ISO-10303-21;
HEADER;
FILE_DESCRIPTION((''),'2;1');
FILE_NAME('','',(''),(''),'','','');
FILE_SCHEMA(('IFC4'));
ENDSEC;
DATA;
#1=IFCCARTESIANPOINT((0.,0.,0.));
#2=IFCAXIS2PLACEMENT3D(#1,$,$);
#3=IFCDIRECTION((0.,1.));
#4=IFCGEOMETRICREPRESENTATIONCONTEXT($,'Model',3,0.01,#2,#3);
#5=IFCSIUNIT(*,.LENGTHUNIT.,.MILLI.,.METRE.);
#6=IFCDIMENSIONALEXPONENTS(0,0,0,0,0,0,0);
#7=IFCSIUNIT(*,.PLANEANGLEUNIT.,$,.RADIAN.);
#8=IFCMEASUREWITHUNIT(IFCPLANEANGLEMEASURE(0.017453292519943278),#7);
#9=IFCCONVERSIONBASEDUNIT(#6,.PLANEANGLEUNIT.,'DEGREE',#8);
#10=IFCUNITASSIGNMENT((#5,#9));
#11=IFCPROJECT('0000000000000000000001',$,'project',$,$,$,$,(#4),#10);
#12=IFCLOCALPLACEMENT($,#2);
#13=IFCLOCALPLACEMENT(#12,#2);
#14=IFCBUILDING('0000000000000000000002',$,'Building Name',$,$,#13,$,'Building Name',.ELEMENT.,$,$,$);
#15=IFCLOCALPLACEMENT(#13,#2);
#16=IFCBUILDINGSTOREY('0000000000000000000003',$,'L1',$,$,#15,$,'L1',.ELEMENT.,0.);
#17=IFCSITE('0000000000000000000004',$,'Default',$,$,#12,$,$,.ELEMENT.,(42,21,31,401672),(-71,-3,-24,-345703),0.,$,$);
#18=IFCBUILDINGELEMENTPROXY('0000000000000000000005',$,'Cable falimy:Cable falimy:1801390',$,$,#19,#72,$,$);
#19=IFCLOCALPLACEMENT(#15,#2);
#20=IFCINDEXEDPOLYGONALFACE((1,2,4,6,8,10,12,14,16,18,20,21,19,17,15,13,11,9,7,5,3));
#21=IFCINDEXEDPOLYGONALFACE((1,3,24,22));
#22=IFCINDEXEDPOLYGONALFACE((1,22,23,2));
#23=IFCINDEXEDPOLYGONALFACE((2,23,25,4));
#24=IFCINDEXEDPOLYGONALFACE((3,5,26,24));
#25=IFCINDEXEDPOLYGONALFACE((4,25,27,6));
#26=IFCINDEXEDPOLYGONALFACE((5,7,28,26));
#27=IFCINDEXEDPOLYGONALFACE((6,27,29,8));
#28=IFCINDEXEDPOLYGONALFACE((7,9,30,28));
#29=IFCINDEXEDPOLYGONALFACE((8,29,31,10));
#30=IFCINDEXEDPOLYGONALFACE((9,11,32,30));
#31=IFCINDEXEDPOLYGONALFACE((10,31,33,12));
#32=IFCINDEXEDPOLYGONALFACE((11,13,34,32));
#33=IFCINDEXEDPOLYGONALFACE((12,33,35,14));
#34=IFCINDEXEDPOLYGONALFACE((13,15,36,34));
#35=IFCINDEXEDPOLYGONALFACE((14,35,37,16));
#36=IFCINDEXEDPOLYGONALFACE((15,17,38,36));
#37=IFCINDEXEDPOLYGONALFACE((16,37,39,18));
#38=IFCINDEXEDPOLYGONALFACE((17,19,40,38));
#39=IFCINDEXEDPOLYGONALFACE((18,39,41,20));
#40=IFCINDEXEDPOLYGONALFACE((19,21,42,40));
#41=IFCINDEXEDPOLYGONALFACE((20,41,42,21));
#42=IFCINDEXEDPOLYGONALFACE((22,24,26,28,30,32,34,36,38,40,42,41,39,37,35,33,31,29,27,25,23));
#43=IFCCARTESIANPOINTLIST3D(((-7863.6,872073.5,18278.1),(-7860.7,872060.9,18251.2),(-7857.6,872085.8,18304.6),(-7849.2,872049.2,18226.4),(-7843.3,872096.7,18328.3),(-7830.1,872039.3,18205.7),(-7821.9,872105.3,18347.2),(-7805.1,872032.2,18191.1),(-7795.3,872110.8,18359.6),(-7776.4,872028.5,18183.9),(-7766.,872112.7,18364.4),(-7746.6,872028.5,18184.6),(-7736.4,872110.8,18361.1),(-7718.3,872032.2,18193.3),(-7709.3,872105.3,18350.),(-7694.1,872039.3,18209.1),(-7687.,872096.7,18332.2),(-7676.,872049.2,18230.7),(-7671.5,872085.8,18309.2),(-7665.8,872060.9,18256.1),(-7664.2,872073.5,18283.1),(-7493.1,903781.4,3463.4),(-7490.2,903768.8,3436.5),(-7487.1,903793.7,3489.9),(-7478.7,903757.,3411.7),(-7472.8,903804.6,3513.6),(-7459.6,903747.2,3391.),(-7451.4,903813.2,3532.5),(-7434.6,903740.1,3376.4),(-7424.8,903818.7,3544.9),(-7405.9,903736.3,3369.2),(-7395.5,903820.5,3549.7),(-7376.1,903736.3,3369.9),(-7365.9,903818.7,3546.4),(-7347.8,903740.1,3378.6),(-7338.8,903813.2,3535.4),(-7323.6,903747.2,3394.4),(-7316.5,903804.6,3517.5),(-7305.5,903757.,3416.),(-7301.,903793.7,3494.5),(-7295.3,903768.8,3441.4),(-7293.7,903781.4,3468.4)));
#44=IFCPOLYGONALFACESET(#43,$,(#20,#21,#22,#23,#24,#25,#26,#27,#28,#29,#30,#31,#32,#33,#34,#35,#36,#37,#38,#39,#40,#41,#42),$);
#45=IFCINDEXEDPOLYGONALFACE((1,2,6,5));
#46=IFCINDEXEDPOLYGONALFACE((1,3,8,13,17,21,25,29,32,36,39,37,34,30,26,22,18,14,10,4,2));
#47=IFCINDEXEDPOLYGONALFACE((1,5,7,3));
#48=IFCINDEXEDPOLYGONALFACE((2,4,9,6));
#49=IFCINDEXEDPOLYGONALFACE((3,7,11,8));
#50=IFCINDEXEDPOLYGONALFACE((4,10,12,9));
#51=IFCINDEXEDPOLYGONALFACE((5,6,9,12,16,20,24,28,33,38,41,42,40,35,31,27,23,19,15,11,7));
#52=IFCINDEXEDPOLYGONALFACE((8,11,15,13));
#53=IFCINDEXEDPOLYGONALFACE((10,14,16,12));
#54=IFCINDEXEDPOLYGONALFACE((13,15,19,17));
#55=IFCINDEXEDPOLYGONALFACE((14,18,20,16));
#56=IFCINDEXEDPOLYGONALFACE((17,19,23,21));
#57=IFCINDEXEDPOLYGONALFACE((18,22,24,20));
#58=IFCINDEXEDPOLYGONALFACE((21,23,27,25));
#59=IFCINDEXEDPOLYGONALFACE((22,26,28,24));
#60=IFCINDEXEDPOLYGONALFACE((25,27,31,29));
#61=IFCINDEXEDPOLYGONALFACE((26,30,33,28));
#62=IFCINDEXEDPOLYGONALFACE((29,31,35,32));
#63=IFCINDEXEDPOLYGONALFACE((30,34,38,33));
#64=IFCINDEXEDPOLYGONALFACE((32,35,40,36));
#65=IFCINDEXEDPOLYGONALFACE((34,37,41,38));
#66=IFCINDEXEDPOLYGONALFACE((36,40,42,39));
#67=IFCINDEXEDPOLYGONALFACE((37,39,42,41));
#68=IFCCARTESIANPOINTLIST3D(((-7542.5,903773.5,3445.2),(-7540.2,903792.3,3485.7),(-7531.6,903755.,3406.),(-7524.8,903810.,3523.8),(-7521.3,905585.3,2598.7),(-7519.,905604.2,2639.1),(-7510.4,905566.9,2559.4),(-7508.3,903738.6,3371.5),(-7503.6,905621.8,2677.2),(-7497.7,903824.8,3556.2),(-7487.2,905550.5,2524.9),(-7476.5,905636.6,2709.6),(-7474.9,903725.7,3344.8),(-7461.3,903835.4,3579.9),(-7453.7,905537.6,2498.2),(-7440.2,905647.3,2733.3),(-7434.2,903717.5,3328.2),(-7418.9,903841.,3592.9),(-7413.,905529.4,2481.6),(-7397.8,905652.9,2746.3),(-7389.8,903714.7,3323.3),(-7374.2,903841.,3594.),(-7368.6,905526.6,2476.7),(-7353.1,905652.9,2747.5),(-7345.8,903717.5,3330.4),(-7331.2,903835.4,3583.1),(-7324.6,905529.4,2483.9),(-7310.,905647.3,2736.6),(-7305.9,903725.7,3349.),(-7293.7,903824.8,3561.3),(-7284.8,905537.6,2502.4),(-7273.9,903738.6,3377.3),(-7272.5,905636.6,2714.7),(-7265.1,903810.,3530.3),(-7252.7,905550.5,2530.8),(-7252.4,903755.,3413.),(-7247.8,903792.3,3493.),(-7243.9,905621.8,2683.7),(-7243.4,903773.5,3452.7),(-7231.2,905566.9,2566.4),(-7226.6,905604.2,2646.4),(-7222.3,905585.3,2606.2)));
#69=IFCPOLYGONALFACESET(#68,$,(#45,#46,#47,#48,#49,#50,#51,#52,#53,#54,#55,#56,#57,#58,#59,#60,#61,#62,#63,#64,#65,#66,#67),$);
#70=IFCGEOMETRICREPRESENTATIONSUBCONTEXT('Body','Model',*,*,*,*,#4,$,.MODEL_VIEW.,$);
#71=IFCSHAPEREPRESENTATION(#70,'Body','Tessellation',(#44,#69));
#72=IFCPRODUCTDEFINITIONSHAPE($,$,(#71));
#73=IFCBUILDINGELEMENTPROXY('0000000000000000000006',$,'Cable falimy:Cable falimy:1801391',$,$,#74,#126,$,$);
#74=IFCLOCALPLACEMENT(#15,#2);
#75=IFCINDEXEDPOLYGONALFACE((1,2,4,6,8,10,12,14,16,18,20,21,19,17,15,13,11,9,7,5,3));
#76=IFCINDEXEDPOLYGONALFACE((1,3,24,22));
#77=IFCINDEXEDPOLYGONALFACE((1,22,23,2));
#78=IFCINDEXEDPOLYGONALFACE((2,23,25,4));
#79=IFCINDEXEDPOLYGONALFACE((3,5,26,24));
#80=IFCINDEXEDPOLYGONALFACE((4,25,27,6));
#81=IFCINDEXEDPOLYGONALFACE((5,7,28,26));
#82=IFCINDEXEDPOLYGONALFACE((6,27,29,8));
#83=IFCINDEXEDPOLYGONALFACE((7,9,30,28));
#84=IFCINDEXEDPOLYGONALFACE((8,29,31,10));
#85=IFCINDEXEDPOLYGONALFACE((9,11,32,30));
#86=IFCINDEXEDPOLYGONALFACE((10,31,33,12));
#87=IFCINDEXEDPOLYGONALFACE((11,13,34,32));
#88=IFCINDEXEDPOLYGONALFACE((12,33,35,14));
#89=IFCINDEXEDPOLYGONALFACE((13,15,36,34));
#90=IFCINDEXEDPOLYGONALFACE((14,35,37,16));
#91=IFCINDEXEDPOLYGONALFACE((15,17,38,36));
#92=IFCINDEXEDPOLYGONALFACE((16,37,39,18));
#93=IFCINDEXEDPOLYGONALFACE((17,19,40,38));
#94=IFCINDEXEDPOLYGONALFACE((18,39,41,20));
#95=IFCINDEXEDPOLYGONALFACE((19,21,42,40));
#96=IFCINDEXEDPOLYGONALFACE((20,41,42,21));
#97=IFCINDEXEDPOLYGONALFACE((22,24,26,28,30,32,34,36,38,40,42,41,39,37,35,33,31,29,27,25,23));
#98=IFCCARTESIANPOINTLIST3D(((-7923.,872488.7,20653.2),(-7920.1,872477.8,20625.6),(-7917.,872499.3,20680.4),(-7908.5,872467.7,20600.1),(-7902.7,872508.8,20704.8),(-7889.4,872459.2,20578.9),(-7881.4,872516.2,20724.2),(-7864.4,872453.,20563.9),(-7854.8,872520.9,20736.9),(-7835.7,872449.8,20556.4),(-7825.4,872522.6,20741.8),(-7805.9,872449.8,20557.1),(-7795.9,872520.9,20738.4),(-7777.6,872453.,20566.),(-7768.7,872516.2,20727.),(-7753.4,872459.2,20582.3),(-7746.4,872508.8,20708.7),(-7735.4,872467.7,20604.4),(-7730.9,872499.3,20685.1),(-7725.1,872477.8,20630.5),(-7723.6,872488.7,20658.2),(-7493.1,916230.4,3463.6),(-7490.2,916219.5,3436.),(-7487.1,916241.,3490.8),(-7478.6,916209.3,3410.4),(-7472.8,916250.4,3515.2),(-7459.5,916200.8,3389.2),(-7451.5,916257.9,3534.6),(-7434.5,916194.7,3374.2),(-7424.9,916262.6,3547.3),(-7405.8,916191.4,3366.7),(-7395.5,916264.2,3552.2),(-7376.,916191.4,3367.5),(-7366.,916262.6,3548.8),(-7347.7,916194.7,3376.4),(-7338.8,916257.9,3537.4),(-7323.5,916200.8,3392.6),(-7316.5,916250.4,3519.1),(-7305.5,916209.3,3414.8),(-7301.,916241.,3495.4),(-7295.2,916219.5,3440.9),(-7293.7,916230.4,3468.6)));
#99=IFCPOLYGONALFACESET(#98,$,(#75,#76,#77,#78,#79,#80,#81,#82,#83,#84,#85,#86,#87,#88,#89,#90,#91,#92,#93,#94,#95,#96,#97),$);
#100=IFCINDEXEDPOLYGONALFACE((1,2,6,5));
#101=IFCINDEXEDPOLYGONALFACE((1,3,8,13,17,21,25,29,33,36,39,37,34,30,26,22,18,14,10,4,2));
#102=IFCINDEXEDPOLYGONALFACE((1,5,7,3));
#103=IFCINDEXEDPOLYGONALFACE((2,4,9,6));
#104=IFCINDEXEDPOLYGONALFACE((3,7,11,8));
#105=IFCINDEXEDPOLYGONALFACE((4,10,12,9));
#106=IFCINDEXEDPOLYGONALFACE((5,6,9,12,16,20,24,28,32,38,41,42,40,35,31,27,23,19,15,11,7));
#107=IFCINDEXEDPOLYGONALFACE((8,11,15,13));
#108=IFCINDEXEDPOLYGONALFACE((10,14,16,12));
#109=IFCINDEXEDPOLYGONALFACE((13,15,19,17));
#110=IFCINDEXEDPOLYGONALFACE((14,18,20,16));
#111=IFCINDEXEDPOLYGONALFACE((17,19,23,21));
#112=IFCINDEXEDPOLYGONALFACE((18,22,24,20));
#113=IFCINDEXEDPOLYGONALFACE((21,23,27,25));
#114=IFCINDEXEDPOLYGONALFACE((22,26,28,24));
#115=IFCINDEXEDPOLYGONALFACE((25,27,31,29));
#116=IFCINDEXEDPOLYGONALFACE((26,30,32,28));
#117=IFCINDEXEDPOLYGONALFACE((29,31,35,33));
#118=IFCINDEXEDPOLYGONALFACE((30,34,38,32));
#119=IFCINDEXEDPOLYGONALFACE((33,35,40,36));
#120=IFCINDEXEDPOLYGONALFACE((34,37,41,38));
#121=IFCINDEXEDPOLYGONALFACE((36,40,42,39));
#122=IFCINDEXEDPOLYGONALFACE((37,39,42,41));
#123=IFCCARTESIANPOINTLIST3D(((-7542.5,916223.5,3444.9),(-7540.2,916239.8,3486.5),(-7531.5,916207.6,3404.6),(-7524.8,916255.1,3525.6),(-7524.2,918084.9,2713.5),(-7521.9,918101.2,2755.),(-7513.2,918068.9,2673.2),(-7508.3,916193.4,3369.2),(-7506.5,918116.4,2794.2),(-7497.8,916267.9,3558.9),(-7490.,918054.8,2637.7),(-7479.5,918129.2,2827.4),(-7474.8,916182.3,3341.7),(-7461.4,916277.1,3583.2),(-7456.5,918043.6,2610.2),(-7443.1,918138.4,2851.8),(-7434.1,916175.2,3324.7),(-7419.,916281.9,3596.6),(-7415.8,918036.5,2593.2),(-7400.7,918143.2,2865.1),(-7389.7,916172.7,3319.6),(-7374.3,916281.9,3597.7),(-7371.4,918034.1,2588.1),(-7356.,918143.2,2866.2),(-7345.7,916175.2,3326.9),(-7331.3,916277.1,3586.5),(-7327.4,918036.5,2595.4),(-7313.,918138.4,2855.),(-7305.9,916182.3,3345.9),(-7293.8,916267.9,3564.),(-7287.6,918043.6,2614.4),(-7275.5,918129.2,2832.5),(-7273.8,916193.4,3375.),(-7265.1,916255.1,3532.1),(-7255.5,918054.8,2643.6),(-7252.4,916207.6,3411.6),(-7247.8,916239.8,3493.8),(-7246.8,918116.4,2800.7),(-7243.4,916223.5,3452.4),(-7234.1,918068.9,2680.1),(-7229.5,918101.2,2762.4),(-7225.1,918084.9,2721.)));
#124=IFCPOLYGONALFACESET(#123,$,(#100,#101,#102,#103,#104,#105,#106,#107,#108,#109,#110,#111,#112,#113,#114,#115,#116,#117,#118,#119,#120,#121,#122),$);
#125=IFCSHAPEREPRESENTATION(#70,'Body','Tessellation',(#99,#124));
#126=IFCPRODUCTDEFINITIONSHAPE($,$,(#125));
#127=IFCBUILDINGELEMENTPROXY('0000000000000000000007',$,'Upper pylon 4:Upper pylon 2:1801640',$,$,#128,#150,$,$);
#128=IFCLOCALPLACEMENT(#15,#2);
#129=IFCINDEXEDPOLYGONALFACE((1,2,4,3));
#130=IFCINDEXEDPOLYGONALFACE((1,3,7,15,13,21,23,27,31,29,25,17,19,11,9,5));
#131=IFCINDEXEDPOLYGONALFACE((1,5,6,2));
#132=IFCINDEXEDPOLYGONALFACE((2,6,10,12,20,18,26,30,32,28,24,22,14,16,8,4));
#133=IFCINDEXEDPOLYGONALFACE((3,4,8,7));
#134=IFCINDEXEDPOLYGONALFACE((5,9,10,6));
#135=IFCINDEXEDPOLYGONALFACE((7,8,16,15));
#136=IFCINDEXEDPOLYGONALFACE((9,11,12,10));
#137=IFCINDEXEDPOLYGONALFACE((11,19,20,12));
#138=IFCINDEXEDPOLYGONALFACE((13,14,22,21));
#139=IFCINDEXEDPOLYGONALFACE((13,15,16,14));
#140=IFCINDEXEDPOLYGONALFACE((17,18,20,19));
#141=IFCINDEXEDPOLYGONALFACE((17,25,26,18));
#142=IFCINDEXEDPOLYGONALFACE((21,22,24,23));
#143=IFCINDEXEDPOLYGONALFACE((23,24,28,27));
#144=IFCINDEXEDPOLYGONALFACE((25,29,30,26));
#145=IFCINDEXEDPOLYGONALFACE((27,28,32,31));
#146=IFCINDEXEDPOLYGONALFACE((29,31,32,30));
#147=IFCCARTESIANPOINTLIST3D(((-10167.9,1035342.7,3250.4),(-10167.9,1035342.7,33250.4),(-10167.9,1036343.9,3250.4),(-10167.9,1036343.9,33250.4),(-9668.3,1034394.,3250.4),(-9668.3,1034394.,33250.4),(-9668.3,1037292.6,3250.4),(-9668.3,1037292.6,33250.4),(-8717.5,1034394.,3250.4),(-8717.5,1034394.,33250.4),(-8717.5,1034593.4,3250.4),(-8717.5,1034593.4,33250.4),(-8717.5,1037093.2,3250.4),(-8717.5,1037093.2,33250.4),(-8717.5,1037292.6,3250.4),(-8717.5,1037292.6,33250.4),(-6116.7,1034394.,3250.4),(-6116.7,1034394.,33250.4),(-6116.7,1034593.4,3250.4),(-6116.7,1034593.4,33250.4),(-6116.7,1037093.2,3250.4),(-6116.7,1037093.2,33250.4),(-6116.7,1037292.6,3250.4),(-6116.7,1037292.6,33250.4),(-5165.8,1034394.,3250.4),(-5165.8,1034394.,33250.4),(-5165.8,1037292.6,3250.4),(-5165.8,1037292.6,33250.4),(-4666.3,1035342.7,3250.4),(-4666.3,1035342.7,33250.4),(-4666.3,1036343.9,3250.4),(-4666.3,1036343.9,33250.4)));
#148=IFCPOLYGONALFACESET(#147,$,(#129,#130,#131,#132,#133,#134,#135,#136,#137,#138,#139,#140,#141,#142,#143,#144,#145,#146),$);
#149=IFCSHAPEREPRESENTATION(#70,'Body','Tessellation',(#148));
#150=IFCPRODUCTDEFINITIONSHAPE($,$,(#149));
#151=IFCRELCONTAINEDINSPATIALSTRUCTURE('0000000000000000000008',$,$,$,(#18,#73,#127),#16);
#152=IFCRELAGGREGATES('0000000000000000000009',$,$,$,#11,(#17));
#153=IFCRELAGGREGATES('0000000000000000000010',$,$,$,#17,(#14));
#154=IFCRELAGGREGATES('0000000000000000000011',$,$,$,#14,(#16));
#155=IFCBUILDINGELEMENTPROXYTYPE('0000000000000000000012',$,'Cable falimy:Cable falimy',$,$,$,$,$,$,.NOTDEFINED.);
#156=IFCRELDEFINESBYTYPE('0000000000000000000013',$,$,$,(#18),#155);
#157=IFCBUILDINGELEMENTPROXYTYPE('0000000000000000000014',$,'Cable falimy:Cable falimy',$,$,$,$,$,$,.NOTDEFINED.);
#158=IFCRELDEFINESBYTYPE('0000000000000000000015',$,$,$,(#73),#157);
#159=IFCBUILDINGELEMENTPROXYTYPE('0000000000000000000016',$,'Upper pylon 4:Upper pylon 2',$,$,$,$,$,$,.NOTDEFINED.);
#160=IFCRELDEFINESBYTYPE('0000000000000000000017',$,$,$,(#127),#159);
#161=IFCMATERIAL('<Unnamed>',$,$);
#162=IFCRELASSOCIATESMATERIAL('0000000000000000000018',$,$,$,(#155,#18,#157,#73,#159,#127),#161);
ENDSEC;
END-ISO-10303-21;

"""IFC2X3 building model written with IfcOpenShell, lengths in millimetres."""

from ifc_helpers import new_model, entity, si_unit, converted_unit, direction, frame, frame_2d, origin, place, context, subcontext, project, spatial, polyline, circle, outline, extrude, source, transform, mapped, material, type_object, type_shapes, element, save


model = new_model("IFC2X3")

# Units and contexts
model_context = context("Model", 3, precision=0.01, world=origin(), true_north=direction((0.0, 1.0)))
body_context = subcontext(model_context, "Body", "Model", "MODEL_VIEW")
ifc_project = project(units=[si_unit("LENGTHUNIT", "METRE", prefix="MILLI"), converted_unit("PLANEANGLEUNIT", "DEGREE", entity("IfcPlaneAngleMeasure", 0.017453292519943278), si_unit("PLANEANGLEUNIT", "RADIAN"), dimensions=[0, 0, 0, 0, 0, 0, 0])], contexts=[model_context])

# Site, building, storey
site_placement = place(None, origin())
site = spatial("IfcSite", under=ifc_project, at=site_placement, Name="Default", CompositionType="ELEMENT", RefLatitude=(42, 21, 31, 401672), RefLongitude=(-71, -3, -24, -345703), RefElevation=0.0)
building_placement = place(site_placement, origin())
building = spatial("IfcBuilding", under=site, at=building_placement, Name="Building Name", LongName="Building Name", CompositionType="ELEMENT")
storey_placement = place(building_placement, origin())
storey = spatial("IfcBuildingStorey", under=building, at=storey_placement, Name="L1", LongName="L1", CompositionType="ELEMENT", Elevation=0.0)

# Shared definitions
ifc_material = material(Name="<Unnamed>")

# Building element proxies
building_element_proxy_type_1 = type_object("IfcBuildingElementProxyType", Name="Cable falimy:Cable falimy", PredefinedType="NOTDEFINED", material=ifc_material)
shared_shape_1 = source(origin(), body_context, "Body", "SweptSolid", [
    extrude(circle(Radius=100.0, at=frame_2d((0.0, 0.0), x_axis=(1.0, 0.0))), frame((0.0, 0.0, 0.0), z_axis=(0.905939, 0.0, 0.423409), x_axis=(-0.423409, 0.0, 0.905939)), (0.0, 0.0, 1.0), 35000.0),
    extrude(circle(Radius=150.0, at=frame_2d((0.0, 0.0), x_axis=(1.0, 0.0))), frame((-1811.9, 0.0, -846.8), z_axis=(0.905939, 0.0, 0.423409), x_axis=(0.423409, 0.0, -0.905939)), (0.0, 0.0, 1.0), 2000.0),
])
type_shapes(building_element_proxy_type_1, [shared_shape_1])
proxy_1_placement = place(storey_placement, frame((-7393.2, 903778.2, 3459.1), z_axis=(-0.025001, 0.0, 0.999687), x_axis=(0.0, -1.0, 0.0)))
element("IfcBuildingElementProxy", 1, at=proxy_1_placement, inside=storey, type_object=building_element_proxy_type_1, material=ifc_material, Name="Cable falimy:Cable falimy:1801390", context=body_context, shape_type="MappedRepresentation", body=[
    mapped(shared_shape_1, transform((0.0, 0.0, 0.0), scale=1.0)),
])
building_element_proxy_type_2 = type_object("IfcBuildingElementProxyType", Name="Cable falimy:Cable falimy", PredefinedType="NOTDEFINED", material=ifc_material)
shared_shape_2 = source(origin(), body_context, "Body", "SweptSolid", [
    extrude(circle(Radius=100.0, at=frame_2d((0.0, 0.0), x_axis=(1.0, 0.0))), frame((0.0, 0.0, 0.0), z_axis=(0.930673, 0.0, 0.365852), x_axis=(-0.365852, 0.0, 0.930673)), (0.0, 0.0, 1.0), 47000.0),
    extrude(circle(Radius=150.0, at=frame_2d((0.0, 0.0), x_axis=(1.0, 0.0))), frame((-1861.3, 0.0, -731.7), z_axis=(0.930673, 0.0, 0.365852), x_axis=(0.365852, 0.0, -0.930673)), (0.0, 0.0, 1.0), 2000.0),
])
type_shapes(building_element_proxy_type_2, [shared_shape_2])
proxy_2_placement = place(storey_placement, frame((-7393.2, 916227.6, 3459.1), z_axis=(-0.025001, 0.0, 0.999687), x_axis=(0.0, -1.0, 0.0)))
element("IfcBuildingElementProxy", 2, at=proxy_2_placement, inside=storey, type_object=building_element_proxy_type_2, material=ifc_material, Name="Cable falimy:Cable falimy:1801391", context=body_context, shape_type="MappedRepresentation", body=[
    mapped(shared_shape_2, transform((0.0, 0.0, 0.0), scale=1.0)),
])
building_element_proxy_type_3 = type_object("IfcBuildingElementProxyType", Name="Upper pylon 4:Upper pylon 2", PredefinedType="NOTDEFINED", material=ifc_material)
shared_shape_3 = source(origin(), body_context, "Body", "SweptSolid", [
    extrude(outline(polyline([(1300.4, -1449.3), (2251.3, -1449.3), (2750.8, -500.6), (2750.8, 500.6), (2251.3, 1449.3), (1300.4, 1449.3), (1300.4, 1249.9), (-1300.4, 1249.9), (-1300.4, 1449.3), (-2251.3, 1449.3), (-2750.8, 500.6), (-2750.8, -500.6), (-2251.3, -1449.3), (-1300.4, -1449.3), (-1300.4, -1249.9), (1300.4, -1249.9), (1300.4, -1449.3)])), frame((68629.5, 106372.9, 3609.7), z_axis=(0.0, 0.0, 1.0), x_axis=(-1.0, 0.0, 0.0)), (0.0, 0.0, 1.0), 30000.0),
])
type_shapes(building_element_proxy_type_3, [shared_shape_3])
proxy_3_placement = place(storey_placement, frame((-76046.6, 929470.4, -359.3)))
element("IfcBuildingElementProxy", 3, at=proxy_3_placement, inside=storey, type_object=building_element_proxy_type_3, material=ifc_material, Name="Upper pylon 4:Upper pylon 2:1801640", context=body_context, shape_type="MappedRepresentation", body=[
    mapped(shared_shape_3, transform((0.0, 0.0, 0.0), scale=1.0)),
])

save(model, "model.ifc")
